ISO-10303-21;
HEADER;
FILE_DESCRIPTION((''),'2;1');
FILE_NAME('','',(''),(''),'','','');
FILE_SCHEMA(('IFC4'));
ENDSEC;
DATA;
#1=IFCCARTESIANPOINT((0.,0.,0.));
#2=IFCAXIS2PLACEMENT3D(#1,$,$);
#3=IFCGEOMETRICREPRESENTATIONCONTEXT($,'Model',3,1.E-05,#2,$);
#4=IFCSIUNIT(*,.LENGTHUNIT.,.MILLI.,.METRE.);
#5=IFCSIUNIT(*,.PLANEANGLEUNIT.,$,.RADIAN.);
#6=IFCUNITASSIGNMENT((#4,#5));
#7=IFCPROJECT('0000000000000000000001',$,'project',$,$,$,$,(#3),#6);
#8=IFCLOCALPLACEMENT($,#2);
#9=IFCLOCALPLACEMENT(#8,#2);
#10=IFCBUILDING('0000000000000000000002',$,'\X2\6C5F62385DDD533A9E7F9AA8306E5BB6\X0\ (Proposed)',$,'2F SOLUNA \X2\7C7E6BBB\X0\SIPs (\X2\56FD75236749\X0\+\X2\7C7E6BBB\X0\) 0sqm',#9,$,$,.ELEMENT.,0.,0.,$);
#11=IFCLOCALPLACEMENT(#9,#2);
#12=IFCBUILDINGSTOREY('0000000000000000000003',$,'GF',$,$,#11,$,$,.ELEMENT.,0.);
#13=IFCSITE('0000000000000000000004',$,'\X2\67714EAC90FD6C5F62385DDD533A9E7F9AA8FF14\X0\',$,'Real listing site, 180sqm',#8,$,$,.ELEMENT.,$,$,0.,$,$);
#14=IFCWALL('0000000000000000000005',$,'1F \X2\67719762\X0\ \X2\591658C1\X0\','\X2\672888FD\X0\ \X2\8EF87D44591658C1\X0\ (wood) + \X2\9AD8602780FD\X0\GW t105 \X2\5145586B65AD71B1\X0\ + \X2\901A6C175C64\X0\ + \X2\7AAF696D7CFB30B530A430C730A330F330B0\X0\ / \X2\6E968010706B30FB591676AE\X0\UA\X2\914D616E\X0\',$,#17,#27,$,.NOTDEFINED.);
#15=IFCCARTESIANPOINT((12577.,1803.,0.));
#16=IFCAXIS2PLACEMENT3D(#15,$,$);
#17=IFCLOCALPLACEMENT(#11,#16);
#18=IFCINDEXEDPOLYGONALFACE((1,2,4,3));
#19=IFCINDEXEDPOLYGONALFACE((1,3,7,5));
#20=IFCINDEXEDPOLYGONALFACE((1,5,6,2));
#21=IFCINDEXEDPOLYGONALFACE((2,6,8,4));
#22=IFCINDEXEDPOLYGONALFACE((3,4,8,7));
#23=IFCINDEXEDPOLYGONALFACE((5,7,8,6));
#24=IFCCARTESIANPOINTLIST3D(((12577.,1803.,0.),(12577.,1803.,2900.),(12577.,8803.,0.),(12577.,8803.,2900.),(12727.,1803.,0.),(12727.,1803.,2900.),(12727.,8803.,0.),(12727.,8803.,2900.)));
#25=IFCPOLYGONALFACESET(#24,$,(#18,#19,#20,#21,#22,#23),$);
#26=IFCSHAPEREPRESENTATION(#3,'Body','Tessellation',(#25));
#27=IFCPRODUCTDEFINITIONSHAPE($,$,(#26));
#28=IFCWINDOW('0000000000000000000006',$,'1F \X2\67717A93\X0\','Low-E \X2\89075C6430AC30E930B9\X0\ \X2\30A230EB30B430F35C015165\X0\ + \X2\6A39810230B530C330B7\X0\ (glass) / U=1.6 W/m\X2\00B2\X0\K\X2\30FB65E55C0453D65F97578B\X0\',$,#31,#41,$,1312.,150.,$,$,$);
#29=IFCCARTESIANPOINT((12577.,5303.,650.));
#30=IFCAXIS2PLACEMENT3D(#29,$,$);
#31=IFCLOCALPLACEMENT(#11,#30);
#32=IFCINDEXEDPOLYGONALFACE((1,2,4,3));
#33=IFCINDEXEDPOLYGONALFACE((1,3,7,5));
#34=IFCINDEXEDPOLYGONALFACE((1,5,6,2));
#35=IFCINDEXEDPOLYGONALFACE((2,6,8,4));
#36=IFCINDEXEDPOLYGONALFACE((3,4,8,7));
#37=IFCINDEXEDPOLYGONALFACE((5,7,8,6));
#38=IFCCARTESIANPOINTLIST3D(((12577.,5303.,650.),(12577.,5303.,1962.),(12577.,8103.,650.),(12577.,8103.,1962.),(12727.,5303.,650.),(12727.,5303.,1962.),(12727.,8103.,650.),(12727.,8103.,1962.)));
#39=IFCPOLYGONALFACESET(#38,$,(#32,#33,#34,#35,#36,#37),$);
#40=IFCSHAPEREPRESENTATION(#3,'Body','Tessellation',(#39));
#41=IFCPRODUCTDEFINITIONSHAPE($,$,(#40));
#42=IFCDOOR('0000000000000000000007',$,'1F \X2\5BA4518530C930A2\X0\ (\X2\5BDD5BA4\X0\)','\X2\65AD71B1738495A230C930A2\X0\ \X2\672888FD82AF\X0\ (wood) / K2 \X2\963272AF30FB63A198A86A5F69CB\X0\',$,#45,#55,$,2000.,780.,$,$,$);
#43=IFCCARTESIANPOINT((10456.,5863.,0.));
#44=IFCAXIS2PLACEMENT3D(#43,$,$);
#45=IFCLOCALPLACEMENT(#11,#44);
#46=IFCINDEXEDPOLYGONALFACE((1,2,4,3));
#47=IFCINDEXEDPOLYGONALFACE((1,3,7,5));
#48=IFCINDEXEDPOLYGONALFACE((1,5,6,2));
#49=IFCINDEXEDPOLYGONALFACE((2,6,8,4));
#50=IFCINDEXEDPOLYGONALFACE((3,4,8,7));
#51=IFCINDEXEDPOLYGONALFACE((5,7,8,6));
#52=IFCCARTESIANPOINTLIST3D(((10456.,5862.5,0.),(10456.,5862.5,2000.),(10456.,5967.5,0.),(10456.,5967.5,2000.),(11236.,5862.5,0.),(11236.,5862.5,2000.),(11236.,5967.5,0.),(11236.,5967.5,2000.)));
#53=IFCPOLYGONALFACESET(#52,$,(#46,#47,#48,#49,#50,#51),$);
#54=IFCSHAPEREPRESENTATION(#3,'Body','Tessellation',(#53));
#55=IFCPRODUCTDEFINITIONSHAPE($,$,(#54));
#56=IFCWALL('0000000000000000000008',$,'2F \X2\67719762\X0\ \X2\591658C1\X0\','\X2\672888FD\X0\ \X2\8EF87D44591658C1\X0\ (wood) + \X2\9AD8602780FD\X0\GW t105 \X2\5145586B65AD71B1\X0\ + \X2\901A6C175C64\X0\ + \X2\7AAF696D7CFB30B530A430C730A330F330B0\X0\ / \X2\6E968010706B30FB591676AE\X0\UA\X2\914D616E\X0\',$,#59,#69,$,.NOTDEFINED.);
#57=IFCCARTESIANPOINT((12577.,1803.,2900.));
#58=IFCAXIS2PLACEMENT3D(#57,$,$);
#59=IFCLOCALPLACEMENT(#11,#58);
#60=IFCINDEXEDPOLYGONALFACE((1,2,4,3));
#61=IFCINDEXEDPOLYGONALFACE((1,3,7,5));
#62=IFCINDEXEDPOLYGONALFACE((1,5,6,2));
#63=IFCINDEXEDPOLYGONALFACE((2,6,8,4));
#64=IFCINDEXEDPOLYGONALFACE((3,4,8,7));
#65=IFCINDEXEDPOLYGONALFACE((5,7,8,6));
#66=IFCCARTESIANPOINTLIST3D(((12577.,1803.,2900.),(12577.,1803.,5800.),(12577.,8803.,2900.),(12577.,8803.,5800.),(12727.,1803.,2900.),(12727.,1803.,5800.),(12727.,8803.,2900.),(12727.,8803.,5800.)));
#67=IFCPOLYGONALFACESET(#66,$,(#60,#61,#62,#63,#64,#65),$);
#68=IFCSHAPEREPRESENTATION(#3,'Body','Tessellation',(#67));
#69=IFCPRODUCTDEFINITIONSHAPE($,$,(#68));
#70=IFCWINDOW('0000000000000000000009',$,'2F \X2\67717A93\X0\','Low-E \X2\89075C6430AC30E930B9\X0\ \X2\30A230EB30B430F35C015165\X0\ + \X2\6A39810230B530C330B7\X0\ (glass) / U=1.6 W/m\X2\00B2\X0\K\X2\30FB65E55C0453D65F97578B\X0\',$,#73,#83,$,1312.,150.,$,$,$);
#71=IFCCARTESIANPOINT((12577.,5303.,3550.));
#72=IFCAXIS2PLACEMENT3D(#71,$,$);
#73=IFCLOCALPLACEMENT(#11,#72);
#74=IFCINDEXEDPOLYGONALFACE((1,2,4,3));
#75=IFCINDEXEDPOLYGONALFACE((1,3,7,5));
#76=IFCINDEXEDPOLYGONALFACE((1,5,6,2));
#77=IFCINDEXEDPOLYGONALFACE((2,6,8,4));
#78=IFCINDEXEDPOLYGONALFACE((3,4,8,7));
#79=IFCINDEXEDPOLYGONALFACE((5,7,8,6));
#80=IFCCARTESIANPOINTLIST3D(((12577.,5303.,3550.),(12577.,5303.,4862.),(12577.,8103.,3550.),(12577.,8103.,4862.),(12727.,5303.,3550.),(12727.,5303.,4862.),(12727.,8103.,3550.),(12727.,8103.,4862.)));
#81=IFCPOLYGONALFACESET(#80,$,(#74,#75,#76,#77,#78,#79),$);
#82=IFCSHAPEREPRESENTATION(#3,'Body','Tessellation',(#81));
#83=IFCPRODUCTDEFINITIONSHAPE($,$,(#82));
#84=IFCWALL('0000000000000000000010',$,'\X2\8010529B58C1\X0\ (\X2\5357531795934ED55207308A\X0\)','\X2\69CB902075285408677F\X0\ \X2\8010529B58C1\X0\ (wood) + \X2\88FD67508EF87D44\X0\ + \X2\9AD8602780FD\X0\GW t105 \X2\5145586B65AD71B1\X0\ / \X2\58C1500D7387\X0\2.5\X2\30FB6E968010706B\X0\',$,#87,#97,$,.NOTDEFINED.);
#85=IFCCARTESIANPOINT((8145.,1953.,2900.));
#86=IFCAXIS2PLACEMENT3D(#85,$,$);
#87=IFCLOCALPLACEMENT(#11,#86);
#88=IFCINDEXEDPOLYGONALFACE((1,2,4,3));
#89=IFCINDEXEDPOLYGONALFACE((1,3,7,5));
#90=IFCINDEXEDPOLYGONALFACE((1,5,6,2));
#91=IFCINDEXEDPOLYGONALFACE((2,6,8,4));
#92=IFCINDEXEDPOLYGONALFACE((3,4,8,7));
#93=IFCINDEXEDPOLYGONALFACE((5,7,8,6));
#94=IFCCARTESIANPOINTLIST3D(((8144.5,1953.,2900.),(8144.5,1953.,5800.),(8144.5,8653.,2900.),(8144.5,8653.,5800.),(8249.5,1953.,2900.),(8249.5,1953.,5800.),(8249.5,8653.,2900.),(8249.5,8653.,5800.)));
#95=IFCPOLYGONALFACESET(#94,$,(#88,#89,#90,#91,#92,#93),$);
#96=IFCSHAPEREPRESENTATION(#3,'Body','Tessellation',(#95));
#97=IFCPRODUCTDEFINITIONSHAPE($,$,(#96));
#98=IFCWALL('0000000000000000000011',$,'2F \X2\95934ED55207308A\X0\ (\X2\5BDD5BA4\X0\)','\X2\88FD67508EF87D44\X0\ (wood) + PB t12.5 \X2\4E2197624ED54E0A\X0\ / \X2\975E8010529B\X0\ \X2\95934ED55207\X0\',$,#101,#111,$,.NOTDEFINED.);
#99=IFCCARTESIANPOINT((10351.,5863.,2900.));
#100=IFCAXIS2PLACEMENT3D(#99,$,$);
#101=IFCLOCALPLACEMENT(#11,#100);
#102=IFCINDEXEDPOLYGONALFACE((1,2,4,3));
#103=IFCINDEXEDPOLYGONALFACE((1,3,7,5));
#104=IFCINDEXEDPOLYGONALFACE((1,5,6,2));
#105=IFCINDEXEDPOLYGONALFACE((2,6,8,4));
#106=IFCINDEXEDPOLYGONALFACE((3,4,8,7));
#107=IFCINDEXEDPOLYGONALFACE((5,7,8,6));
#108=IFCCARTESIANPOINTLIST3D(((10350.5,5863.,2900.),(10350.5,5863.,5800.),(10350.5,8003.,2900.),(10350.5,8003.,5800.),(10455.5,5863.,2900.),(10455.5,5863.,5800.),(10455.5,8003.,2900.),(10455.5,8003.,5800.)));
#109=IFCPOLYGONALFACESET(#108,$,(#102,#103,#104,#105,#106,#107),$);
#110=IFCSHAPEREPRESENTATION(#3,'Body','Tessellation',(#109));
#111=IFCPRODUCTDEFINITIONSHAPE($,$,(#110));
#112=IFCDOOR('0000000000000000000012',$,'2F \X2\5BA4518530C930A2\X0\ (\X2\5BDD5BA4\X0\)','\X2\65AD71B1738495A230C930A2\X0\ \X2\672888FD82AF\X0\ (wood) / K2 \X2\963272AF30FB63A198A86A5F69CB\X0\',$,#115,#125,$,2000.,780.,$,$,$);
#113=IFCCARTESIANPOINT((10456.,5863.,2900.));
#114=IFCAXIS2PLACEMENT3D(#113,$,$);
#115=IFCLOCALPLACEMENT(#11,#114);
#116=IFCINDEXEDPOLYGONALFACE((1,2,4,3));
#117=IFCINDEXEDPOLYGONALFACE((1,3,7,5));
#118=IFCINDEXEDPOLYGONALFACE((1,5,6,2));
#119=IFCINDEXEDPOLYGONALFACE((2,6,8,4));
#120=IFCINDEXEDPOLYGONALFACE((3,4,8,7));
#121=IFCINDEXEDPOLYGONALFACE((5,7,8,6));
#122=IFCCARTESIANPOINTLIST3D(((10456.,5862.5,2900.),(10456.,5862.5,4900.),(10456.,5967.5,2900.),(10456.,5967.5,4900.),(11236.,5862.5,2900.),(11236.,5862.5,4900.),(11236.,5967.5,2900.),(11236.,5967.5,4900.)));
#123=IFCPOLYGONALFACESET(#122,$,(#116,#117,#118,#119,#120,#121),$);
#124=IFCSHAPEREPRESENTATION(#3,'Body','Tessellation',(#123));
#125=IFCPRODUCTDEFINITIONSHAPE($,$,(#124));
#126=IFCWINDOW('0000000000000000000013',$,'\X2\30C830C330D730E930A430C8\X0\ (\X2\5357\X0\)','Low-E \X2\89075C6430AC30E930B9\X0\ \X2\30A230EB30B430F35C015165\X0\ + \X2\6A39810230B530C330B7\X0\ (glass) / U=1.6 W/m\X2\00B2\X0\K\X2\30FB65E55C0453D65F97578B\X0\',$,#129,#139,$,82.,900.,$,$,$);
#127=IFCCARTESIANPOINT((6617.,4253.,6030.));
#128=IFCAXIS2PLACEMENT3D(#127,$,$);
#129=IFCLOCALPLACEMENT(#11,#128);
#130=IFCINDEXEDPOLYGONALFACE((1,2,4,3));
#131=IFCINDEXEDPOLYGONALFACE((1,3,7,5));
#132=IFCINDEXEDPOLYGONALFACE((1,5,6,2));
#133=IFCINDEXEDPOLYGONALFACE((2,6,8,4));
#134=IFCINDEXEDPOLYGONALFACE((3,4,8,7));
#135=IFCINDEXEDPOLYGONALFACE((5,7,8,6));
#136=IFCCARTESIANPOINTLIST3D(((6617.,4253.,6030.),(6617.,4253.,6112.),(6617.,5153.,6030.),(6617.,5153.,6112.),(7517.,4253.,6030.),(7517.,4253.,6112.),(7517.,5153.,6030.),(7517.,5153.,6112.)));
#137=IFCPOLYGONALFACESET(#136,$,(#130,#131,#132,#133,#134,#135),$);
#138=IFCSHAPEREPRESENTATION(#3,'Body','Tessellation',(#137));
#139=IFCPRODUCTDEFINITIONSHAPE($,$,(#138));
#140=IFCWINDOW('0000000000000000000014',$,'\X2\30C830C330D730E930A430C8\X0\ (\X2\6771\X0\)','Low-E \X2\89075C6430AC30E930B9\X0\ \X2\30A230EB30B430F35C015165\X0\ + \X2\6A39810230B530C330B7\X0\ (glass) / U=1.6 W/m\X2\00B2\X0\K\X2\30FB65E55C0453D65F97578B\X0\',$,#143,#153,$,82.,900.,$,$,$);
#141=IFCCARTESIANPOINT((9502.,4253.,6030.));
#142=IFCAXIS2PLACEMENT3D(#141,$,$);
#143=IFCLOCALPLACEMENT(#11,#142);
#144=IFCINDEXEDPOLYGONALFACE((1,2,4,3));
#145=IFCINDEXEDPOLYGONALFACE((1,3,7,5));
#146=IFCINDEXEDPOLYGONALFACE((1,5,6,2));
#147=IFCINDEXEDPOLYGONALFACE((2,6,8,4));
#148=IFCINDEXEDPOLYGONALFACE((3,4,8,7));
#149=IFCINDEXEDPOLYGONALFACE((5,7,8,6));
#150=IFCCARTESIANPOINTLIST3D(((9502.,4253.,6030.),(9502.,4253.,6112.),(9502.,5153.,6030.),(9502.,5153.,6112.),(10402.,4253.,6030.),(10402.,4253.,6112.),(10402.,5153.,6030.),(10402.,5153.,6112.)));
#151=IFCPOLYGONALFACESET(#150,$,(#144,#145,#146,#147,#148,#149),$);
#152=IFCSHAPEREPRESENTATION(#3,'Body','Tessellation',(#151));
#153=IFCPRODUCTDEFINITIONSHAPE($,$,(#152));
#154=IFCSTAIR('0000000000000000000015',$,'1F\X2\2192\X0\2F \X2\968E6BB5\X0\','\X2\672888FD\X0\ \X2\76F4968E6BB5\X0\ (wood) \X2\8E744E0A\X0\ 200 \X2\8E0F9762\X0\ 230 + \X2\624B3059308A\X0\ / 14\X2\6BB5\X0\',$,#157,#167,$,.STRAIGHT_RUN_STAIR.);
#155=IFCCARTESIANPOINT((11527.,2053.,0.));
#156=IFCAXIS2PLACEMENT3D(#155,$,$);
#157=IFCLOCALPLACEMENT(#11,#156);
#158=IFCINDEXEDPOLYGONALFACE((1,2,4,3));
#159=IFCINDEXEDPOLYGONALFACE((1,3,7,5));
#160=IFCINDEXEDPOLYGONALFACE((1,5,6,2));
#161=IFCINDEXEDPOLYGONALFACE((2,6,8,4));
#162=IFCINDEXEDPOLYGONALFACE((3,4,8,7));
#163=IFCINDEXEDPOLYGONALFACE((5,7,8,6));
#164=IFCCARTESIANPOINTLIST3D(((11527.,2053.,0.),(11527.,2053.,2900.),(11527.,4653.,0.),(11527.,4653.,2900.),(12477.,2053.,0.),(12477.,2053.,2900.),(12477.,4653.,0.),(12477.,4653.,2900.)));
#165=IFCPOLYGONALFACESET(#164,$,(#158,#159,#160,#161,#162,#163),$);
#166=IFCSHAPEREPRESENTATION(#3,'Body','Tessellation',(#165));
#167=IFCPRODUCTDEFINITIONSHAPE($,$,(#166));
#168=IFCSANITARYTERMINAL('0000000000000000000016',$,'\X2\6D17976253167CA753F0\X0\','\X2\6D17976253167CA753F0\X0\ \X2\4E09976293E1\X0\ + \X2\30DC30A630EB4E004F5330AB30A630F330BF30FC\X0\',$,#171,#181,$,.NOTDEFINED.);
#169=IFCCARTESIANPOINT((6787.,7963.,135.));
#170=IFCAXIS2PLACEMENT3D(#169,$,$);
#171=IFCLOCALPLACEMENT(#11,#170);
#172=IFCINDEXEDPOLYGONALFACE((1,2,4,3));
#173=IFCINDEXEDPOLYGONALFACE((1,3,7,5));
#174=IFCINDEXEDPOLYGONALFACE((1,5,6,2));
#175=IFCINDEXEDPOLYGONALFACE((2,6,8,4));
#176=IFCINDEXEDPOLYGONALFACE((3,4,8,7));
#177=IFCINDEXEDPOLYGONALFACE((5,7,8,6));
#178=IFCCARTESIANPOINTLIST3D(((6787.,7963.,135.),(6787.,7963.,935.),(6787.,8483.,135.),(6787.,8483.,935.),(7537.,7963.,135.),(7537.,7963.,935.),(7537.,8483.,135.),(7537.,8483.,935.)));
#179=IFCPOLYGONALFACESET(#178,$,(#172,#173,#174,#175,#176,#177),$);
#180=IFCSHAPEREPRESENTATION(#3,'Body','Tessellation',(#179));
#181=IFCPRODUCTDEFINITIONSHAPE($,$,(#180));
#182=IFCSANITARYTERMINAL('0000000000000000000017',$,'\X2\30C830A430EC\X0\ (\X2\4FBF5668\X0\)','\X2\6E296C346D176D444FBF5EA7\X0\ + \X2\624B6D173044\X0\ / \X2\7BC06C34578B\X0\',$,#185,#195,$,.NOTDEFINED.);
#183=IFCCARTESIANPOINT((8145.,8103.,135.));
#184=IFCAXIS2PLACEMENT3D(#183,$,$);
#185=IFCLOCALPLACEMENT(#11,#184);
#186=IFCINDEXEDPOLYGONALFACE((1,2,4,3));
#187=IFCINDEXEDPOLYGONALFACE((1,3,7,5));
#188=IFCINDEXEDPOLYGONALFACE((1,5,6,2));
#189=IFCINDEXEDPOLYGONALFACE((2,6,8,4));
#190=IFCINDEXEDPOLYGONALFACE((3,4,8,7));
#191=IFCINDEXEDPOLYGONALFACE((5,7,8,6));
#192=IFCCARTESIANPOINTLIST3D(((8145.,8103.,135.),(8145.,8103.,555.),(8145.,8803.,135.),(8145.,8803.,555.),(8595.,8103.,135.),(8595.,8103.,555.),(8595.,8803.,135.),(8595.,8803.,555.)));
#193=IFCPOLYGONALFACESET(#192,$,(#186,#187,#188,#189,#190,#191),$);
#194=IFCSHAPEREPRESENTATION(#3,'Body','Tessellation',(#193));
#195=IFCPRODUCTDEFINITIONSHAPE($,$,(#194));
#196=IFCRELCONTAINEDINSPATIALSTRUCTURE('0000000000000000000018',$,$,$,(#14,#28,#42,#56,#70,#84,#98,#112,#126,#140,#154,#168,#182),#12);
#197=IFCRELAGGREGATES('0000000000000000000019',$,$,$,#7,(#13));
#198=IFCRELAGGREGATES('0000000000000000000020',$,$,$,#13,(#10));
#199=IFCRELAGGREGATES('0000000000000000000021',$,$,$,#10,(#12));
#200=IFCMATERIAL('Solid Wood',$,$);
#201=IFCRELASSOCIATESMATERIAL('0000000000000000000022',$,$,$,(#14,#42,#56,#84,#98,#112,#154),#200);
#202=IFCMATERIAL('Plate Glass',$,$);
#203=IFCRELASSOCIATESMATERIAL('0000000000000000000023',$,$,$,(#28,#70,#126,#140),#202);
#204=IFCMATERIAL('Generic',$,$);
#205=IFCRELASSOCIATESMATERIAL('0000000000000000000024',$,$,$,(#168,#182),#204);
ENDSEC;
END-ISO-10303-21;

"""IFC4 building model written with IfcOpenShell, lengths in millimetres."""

from ifc_helpers import new_model, si_unit, frame, frame_2d, origin, place, context, project, spatial, rectangle, extrude, material, element, fill, save


model = new_model("IFC4")

# Units and contexts
model_context = context("Model", 3, precision=1e-05, world=origin())
ifc_project = project(units=[si_unit("LENGTHUNIT", "METRE", prefix="MILLI"), si_unit("PLANEANGLEUNIT", "RADIAN")], contexts=[model_context])

# Site, building, storey
site_placement = place(None, origin())
site = spatial("IfcSite", under=ifc_project, at=site_placement, Name="東京都江戸川区鹿骨４", ObjectType="Real listing site, 180sqm", CompositionType="ELEMENT", RefElevation=0.0)
building_placement = place(site_placement, origin())
building = spatial("IfcBuilding", under=site, at=building_placement, Name="江戸川区鹿骨の家 (Proposed)", ObjectType="2F SOLUNA 籾殻SIPs (国産杉+籾殻) 0sqm", CompositionType="ELEMENT", ElevationOfRefHeight=0.0, ElevationOfTerrain=0.0)
storey_placement = place(building_placement, origin())
storey = spatial("IfcBuildingStorey", under=building, at=storey_placement, Name="GF", CompositionType="ELEMENT", Elevation=0.0)

# Wall, opening, window
ifc_material_1 = material(Name="Solid Wood")
wall_1_placement = place(storey_placement, frame((12577.0, 1803.0, 0.0)))
wall_1 = element("IfcWall", 1, at=wall_1_placement, inside=storey, material=ifc_material_1, Name="1F 東面 外壁", Description="木製 軸組外壁 (wood) + 高性能GW t105 充填断熱 + 通気層 + 窯業系サイディング / 準耐火・外皮UA配慮", PredefinedType="NOTDEFINED", context=model_context, shape_type="SweptSolid", body=[
    extrude(rectangle(XDim=150.0, YDim=7000.0, at=frame_2d((75.0, 3500.0))), frame((12577.0, 1803.0, 0.0)), (0.0, 0.0, 1.0), 2900.0),
])
opening_1_placement = place(storey_placement, frame((12577.0, 5303.0, 650.0)))
opening_1 = element("IfcOpeningElement", 2, at=opening_1_placement, cuts=wall_1, PredefinedType="NOTDEFINED", context=model_context, shape_type="SweptSolid", body=[
    extrude(rectangle(XDim=150.0, YDim=2800.0, at=frame_2d((75.0, 1400.0))), frame((12577.0, 5303.0, 650.0)), (0.0, 0.0, 1.0), 1312.0),
])
ifc_material_2 = material(Name="Plate Glass")
window_1_placement = place(storey_placement, frame((12577.0, 5303.0, 650.0)))
window_1 = element("IfcWindow", 3, at=window_1_placement, inside=storey, material=ifc_material_2, Name="1F 東窓", Description="Low-E 複層ガラス アルゴン封入 + 樹脂サッシ (glass) / U=1.6 W/m²K・日射取得型", OverallHeight=1312.0, OverallWidth=150.0, context=model_context, shape_type="SweptSolid", body=[
    extrude(rectangle(XDim=150.0, YDim=2800.0, at=frame_2d((75.0, 1400.0))), frame((12577.0, 5303.0, 650.0)), (0.0, 0.0, 1.0), 1312.0),
])
fill(opening_1, window_1)

# Door
door_1_placement = place(storey_placement, frame((10456.0, 5863.0, 0.0)))
element("IfcDoor", 4, at=door_1_placement, inside=storey, material=ifc_material_1, Name="1F 室内ドア (寝室)", Description="断熱玄関ドア 木製芯 (wood) / K2 防犯・採風機構", OverallHeight=2000.0, OverallWidth=780.0, context=model_context, shape_type="SweptSolid", body=[
    extrude(rectangle(XDim=780.0, YDim=105.0, at=frame_2d((390.0, 52.0))), frame((10456.0, 5863.0, 0.0)), (0.0, 0.0, 1.0), 2000.0),
])

# Wall, opening, window
wall_2_placement = place(storey_placement, frame((12577.0, 1803.0, 2900.0)))
wall_2 = element("IfcWall", 5, at=wall_2_placement, inside=storey, material=ifc_material_1, Name="2F 東面 外壁", Description="木製 軸組外壁 (wood) + 高性能GW t105 充填断熱 + 通気層 + 窯業系サイディング / 準耐火・外皮UA配慮", PredefinedType="NOTDEFINED", context=model_context, shape_type="SweptSolid", body=[
    extrude(rectangle(XDim=150.0, YDim=7000.0, at=frame_2d((75.0, 3500.0))), frame((12577.0, 1803.0, 2900.0)), (0.0, 0.0, 1.0), 2900.0),
])
opening_2_placement = place(storey_placement, frame((12577.0, 5303.0, 3550.0)))
opening_2 = element("IfcOpeningElement", 6, at=opening_2_placement, cuts=wall_2, PredefinedType="NOTDEFINED", context=model_context, shape_type="SweptSolid", body=[
    extrude(rectangle(XDim=150.0, YDim=2800.0, at=frame_2d((75.0, 1400.0))), frame((12577.0, 5303.0, 3550.0)), (0.0, 0.0, 1.0), 1312.0),
])
window_2_placement = place(storey_placement, frame((12577.0, 5303.0, 3550.0)))
window_2 = element("IfcWindow", 7, at=window_2_placement, inside=storey, material=ifc_material_2, Name="2F 東窓", Description="Low-E 複層ガラス アルゴン封入 + 樹脂サッシ (glass) / U=1.6 W/m²K・日射取得型", OverallHeight=1312.0, OverallWidth=150.0, context=model_context, shape_type="SweptSolid", body=[
    extrude(rectangle(XDim=150.0, YDim=2800.0, at=frame_2d((75.0, 1400.0))), frame((12577.0, 5303.0, 3550.0)), (0.0, 0.0, 1.0), 1312.0),
])
fill(opening_2, window_2)

# Walls
wall_3_placement = place(storey_placement, frame((8145.0, 1953.0, 2900.0)))
element("IfcWall", 8, at=wall_3_placement, inside=storey, material=ifc_material_1, Name="耐力壁 (南北間仕切り)", Description="構造用合板 耐力壁 (wood) + 製材軸組 + 高性能GW t105 充填断熱 / 壁倍率2.5・準耐火", PredefinedType="NOTDEFINED", context=model_context, shape_type="SweptSolid", body=[
    extrude(rectangle(XDim=105.0, YDim=6700.0, at=frame_2d((52.0, 3350.0))), frame((8145.0, 1953.0, 2900.0)), (0.0, 0.0, 1.0), 2900.0),
])
wall_4_placement = place(storey_placement, frame((10351.0, 5863.0, 2900.0)))
element("IfcWall", 9, at=wall_4_placement, inside=storey, material=ifc_material_1, Name="2F 間仕切り (寝室)", Description="製材軸組 (wood) + PB t12.5 両面仕上 / 非耐力 間仕切", PredefinedType="NOTDEFINED", context=model_context, shape_type="SweptSolid", body=[
    extrude(rectangle(XDim=105.0, YDim=2140.0, at=frame_2d((52.0, 1070.0))), frame((10351.0, 5863.0, 2900.0)), (0.0, 0.0, 1.0), 2900.0),
])

# Door
door_2_placement = place(storey_placement, frame((10456.0, 5863.0, 2900.0)))
element("IfcDoor", 10, at=door_2_placement, inside=storey, material=ifc_material_1, Name="2F 室内ドア (寝室)", Description="断熱玄関ドア 木製芯 (wood) / K2 防犯・採風機構", OverallHeight=2000.0, OverallWidth=780.0, context=model_context, shape_type="SweptSolid", body=[
    extrude(rectangle(XDim=780.0, YDim=105.0, at=frame_2d((390.0, 52.0))), frame((10456.0, 5863.0, 2900.0)), (0.0, 0.0, 1.0), 2000.0),
])

# Windows
window_3_placement = place(storey_placement, frame((6617.0, 4253.0, 6030.0)))
element("IfcWindow", 11, at=window_3_placement, inside=storey, material=ifc_material_2, Name="トップライト (南)", Description="Low-E 複層ガラス アルゴン封入 + 樹脂サッシ (glass) / U=1.6 W/m²K・日射取得型", OverallHeight=82.0, OverallWidth=900.0, context=model_context, shape_type="SweptSolid", body=[
    extrude(rectangle(XDim=900.0, YDim=900.0, at=frame_2d((450.0, 450.0))), frame((6617.0, 4253.0, 6030.0)), (0.0, 0.0, 1.0), 82.0),
])
window_4_placement = place(storey_placement, frame((9502.0, 4253.0, 6030.0)))
element("IfcWindow", 12, at=window_4_placement, inside=storey, material=ifc_material_2, Name="トップライト (東)", Description="Low-E 複層ガラス アルゴン封入 + 樹脂サッシ (glass) / U=1.6 W/m²K・日射取得型", OverallHeight=82.0, OverallWidth=900.0, context=model_context, shape_type="SweptSolid", body=[
    extrude(rectangle(XDim=900.0, YDim=900.0, at=frame_2d((450.0, 450.0))), frame((9502.0, 4253.0, 6030.0)), (0.0, 0.0, 1.0), 82.0),
])

# Stair
stair_placement = place(storey_placement, frame((11527.0, 2053.0, 0.0)))
element("IfcStair", 13, at=stair_placement, inside=storey, material=ifc_material_1, Name="1F→2F 階段", Description="木製 直階段 (wood) 蹴上 200 踏面 230 + 手すり / 14段", PredefinedType="STRAIGHT_RUN_STAIR", context=model_context, shape_type="SweptSolid", body=[
    extrude(rectangle(XDim=950.0, YDim=2600.0, at=frame_2d((475.0, 1300.0))), frame((11527.0, 2053.0, 0.0)), (0.0, 0.0, 1.0), 2900.0),
])

# Sanitary terminals
ifc_material_3 = material(Name="Generic")
sanitary_terminal_1_placement = place(storey_placement, frame((6787.0, 7963.0, 135.0)))
element("IfcSanitaryTerminal", 14, at=sanitary_terminal_1_placement, inside=storey, material=ifc_material_3, Name="洗面化粧台", Description="洗面化粧台 三面鏡 + ボウル一体カウンター", PredefinedType="NOTDEFINED", context=model_context, shape_type="SweptSolid", body=[
    extrude(rectangle(XDim=750.0, YDim=520.0, at=frame_2d((375.0, 260.0))), frame((6787.0, 7963.0, 135.0)), (0.0, 0.0, 1.0), 800.0),
])
sanitary_terminal_2_placement = place(storey_placement, frame((8145.0, 8103.0, 135.0)))
element("IfcSanitaryTerminal", 15, at=sanitary_terminal_2_placement, inside=storey, material=ifc_material_3, Name="トイレ (便器)", Description="温水洗浄便座 + 手洗い / 節水型", PredefinedType="NOTDEFINED", context=model_context, shape_type="SweptSolid", body=[
    extrude(rectangle(XDim=450.0, YDim=700.0, at=frame_2d((225.0, 350.0))), frame((8145.0, 8103.0, 135.0)), (0.0, 0.0, 1.0), 420.0),
])

save(model, "model.ifc")
